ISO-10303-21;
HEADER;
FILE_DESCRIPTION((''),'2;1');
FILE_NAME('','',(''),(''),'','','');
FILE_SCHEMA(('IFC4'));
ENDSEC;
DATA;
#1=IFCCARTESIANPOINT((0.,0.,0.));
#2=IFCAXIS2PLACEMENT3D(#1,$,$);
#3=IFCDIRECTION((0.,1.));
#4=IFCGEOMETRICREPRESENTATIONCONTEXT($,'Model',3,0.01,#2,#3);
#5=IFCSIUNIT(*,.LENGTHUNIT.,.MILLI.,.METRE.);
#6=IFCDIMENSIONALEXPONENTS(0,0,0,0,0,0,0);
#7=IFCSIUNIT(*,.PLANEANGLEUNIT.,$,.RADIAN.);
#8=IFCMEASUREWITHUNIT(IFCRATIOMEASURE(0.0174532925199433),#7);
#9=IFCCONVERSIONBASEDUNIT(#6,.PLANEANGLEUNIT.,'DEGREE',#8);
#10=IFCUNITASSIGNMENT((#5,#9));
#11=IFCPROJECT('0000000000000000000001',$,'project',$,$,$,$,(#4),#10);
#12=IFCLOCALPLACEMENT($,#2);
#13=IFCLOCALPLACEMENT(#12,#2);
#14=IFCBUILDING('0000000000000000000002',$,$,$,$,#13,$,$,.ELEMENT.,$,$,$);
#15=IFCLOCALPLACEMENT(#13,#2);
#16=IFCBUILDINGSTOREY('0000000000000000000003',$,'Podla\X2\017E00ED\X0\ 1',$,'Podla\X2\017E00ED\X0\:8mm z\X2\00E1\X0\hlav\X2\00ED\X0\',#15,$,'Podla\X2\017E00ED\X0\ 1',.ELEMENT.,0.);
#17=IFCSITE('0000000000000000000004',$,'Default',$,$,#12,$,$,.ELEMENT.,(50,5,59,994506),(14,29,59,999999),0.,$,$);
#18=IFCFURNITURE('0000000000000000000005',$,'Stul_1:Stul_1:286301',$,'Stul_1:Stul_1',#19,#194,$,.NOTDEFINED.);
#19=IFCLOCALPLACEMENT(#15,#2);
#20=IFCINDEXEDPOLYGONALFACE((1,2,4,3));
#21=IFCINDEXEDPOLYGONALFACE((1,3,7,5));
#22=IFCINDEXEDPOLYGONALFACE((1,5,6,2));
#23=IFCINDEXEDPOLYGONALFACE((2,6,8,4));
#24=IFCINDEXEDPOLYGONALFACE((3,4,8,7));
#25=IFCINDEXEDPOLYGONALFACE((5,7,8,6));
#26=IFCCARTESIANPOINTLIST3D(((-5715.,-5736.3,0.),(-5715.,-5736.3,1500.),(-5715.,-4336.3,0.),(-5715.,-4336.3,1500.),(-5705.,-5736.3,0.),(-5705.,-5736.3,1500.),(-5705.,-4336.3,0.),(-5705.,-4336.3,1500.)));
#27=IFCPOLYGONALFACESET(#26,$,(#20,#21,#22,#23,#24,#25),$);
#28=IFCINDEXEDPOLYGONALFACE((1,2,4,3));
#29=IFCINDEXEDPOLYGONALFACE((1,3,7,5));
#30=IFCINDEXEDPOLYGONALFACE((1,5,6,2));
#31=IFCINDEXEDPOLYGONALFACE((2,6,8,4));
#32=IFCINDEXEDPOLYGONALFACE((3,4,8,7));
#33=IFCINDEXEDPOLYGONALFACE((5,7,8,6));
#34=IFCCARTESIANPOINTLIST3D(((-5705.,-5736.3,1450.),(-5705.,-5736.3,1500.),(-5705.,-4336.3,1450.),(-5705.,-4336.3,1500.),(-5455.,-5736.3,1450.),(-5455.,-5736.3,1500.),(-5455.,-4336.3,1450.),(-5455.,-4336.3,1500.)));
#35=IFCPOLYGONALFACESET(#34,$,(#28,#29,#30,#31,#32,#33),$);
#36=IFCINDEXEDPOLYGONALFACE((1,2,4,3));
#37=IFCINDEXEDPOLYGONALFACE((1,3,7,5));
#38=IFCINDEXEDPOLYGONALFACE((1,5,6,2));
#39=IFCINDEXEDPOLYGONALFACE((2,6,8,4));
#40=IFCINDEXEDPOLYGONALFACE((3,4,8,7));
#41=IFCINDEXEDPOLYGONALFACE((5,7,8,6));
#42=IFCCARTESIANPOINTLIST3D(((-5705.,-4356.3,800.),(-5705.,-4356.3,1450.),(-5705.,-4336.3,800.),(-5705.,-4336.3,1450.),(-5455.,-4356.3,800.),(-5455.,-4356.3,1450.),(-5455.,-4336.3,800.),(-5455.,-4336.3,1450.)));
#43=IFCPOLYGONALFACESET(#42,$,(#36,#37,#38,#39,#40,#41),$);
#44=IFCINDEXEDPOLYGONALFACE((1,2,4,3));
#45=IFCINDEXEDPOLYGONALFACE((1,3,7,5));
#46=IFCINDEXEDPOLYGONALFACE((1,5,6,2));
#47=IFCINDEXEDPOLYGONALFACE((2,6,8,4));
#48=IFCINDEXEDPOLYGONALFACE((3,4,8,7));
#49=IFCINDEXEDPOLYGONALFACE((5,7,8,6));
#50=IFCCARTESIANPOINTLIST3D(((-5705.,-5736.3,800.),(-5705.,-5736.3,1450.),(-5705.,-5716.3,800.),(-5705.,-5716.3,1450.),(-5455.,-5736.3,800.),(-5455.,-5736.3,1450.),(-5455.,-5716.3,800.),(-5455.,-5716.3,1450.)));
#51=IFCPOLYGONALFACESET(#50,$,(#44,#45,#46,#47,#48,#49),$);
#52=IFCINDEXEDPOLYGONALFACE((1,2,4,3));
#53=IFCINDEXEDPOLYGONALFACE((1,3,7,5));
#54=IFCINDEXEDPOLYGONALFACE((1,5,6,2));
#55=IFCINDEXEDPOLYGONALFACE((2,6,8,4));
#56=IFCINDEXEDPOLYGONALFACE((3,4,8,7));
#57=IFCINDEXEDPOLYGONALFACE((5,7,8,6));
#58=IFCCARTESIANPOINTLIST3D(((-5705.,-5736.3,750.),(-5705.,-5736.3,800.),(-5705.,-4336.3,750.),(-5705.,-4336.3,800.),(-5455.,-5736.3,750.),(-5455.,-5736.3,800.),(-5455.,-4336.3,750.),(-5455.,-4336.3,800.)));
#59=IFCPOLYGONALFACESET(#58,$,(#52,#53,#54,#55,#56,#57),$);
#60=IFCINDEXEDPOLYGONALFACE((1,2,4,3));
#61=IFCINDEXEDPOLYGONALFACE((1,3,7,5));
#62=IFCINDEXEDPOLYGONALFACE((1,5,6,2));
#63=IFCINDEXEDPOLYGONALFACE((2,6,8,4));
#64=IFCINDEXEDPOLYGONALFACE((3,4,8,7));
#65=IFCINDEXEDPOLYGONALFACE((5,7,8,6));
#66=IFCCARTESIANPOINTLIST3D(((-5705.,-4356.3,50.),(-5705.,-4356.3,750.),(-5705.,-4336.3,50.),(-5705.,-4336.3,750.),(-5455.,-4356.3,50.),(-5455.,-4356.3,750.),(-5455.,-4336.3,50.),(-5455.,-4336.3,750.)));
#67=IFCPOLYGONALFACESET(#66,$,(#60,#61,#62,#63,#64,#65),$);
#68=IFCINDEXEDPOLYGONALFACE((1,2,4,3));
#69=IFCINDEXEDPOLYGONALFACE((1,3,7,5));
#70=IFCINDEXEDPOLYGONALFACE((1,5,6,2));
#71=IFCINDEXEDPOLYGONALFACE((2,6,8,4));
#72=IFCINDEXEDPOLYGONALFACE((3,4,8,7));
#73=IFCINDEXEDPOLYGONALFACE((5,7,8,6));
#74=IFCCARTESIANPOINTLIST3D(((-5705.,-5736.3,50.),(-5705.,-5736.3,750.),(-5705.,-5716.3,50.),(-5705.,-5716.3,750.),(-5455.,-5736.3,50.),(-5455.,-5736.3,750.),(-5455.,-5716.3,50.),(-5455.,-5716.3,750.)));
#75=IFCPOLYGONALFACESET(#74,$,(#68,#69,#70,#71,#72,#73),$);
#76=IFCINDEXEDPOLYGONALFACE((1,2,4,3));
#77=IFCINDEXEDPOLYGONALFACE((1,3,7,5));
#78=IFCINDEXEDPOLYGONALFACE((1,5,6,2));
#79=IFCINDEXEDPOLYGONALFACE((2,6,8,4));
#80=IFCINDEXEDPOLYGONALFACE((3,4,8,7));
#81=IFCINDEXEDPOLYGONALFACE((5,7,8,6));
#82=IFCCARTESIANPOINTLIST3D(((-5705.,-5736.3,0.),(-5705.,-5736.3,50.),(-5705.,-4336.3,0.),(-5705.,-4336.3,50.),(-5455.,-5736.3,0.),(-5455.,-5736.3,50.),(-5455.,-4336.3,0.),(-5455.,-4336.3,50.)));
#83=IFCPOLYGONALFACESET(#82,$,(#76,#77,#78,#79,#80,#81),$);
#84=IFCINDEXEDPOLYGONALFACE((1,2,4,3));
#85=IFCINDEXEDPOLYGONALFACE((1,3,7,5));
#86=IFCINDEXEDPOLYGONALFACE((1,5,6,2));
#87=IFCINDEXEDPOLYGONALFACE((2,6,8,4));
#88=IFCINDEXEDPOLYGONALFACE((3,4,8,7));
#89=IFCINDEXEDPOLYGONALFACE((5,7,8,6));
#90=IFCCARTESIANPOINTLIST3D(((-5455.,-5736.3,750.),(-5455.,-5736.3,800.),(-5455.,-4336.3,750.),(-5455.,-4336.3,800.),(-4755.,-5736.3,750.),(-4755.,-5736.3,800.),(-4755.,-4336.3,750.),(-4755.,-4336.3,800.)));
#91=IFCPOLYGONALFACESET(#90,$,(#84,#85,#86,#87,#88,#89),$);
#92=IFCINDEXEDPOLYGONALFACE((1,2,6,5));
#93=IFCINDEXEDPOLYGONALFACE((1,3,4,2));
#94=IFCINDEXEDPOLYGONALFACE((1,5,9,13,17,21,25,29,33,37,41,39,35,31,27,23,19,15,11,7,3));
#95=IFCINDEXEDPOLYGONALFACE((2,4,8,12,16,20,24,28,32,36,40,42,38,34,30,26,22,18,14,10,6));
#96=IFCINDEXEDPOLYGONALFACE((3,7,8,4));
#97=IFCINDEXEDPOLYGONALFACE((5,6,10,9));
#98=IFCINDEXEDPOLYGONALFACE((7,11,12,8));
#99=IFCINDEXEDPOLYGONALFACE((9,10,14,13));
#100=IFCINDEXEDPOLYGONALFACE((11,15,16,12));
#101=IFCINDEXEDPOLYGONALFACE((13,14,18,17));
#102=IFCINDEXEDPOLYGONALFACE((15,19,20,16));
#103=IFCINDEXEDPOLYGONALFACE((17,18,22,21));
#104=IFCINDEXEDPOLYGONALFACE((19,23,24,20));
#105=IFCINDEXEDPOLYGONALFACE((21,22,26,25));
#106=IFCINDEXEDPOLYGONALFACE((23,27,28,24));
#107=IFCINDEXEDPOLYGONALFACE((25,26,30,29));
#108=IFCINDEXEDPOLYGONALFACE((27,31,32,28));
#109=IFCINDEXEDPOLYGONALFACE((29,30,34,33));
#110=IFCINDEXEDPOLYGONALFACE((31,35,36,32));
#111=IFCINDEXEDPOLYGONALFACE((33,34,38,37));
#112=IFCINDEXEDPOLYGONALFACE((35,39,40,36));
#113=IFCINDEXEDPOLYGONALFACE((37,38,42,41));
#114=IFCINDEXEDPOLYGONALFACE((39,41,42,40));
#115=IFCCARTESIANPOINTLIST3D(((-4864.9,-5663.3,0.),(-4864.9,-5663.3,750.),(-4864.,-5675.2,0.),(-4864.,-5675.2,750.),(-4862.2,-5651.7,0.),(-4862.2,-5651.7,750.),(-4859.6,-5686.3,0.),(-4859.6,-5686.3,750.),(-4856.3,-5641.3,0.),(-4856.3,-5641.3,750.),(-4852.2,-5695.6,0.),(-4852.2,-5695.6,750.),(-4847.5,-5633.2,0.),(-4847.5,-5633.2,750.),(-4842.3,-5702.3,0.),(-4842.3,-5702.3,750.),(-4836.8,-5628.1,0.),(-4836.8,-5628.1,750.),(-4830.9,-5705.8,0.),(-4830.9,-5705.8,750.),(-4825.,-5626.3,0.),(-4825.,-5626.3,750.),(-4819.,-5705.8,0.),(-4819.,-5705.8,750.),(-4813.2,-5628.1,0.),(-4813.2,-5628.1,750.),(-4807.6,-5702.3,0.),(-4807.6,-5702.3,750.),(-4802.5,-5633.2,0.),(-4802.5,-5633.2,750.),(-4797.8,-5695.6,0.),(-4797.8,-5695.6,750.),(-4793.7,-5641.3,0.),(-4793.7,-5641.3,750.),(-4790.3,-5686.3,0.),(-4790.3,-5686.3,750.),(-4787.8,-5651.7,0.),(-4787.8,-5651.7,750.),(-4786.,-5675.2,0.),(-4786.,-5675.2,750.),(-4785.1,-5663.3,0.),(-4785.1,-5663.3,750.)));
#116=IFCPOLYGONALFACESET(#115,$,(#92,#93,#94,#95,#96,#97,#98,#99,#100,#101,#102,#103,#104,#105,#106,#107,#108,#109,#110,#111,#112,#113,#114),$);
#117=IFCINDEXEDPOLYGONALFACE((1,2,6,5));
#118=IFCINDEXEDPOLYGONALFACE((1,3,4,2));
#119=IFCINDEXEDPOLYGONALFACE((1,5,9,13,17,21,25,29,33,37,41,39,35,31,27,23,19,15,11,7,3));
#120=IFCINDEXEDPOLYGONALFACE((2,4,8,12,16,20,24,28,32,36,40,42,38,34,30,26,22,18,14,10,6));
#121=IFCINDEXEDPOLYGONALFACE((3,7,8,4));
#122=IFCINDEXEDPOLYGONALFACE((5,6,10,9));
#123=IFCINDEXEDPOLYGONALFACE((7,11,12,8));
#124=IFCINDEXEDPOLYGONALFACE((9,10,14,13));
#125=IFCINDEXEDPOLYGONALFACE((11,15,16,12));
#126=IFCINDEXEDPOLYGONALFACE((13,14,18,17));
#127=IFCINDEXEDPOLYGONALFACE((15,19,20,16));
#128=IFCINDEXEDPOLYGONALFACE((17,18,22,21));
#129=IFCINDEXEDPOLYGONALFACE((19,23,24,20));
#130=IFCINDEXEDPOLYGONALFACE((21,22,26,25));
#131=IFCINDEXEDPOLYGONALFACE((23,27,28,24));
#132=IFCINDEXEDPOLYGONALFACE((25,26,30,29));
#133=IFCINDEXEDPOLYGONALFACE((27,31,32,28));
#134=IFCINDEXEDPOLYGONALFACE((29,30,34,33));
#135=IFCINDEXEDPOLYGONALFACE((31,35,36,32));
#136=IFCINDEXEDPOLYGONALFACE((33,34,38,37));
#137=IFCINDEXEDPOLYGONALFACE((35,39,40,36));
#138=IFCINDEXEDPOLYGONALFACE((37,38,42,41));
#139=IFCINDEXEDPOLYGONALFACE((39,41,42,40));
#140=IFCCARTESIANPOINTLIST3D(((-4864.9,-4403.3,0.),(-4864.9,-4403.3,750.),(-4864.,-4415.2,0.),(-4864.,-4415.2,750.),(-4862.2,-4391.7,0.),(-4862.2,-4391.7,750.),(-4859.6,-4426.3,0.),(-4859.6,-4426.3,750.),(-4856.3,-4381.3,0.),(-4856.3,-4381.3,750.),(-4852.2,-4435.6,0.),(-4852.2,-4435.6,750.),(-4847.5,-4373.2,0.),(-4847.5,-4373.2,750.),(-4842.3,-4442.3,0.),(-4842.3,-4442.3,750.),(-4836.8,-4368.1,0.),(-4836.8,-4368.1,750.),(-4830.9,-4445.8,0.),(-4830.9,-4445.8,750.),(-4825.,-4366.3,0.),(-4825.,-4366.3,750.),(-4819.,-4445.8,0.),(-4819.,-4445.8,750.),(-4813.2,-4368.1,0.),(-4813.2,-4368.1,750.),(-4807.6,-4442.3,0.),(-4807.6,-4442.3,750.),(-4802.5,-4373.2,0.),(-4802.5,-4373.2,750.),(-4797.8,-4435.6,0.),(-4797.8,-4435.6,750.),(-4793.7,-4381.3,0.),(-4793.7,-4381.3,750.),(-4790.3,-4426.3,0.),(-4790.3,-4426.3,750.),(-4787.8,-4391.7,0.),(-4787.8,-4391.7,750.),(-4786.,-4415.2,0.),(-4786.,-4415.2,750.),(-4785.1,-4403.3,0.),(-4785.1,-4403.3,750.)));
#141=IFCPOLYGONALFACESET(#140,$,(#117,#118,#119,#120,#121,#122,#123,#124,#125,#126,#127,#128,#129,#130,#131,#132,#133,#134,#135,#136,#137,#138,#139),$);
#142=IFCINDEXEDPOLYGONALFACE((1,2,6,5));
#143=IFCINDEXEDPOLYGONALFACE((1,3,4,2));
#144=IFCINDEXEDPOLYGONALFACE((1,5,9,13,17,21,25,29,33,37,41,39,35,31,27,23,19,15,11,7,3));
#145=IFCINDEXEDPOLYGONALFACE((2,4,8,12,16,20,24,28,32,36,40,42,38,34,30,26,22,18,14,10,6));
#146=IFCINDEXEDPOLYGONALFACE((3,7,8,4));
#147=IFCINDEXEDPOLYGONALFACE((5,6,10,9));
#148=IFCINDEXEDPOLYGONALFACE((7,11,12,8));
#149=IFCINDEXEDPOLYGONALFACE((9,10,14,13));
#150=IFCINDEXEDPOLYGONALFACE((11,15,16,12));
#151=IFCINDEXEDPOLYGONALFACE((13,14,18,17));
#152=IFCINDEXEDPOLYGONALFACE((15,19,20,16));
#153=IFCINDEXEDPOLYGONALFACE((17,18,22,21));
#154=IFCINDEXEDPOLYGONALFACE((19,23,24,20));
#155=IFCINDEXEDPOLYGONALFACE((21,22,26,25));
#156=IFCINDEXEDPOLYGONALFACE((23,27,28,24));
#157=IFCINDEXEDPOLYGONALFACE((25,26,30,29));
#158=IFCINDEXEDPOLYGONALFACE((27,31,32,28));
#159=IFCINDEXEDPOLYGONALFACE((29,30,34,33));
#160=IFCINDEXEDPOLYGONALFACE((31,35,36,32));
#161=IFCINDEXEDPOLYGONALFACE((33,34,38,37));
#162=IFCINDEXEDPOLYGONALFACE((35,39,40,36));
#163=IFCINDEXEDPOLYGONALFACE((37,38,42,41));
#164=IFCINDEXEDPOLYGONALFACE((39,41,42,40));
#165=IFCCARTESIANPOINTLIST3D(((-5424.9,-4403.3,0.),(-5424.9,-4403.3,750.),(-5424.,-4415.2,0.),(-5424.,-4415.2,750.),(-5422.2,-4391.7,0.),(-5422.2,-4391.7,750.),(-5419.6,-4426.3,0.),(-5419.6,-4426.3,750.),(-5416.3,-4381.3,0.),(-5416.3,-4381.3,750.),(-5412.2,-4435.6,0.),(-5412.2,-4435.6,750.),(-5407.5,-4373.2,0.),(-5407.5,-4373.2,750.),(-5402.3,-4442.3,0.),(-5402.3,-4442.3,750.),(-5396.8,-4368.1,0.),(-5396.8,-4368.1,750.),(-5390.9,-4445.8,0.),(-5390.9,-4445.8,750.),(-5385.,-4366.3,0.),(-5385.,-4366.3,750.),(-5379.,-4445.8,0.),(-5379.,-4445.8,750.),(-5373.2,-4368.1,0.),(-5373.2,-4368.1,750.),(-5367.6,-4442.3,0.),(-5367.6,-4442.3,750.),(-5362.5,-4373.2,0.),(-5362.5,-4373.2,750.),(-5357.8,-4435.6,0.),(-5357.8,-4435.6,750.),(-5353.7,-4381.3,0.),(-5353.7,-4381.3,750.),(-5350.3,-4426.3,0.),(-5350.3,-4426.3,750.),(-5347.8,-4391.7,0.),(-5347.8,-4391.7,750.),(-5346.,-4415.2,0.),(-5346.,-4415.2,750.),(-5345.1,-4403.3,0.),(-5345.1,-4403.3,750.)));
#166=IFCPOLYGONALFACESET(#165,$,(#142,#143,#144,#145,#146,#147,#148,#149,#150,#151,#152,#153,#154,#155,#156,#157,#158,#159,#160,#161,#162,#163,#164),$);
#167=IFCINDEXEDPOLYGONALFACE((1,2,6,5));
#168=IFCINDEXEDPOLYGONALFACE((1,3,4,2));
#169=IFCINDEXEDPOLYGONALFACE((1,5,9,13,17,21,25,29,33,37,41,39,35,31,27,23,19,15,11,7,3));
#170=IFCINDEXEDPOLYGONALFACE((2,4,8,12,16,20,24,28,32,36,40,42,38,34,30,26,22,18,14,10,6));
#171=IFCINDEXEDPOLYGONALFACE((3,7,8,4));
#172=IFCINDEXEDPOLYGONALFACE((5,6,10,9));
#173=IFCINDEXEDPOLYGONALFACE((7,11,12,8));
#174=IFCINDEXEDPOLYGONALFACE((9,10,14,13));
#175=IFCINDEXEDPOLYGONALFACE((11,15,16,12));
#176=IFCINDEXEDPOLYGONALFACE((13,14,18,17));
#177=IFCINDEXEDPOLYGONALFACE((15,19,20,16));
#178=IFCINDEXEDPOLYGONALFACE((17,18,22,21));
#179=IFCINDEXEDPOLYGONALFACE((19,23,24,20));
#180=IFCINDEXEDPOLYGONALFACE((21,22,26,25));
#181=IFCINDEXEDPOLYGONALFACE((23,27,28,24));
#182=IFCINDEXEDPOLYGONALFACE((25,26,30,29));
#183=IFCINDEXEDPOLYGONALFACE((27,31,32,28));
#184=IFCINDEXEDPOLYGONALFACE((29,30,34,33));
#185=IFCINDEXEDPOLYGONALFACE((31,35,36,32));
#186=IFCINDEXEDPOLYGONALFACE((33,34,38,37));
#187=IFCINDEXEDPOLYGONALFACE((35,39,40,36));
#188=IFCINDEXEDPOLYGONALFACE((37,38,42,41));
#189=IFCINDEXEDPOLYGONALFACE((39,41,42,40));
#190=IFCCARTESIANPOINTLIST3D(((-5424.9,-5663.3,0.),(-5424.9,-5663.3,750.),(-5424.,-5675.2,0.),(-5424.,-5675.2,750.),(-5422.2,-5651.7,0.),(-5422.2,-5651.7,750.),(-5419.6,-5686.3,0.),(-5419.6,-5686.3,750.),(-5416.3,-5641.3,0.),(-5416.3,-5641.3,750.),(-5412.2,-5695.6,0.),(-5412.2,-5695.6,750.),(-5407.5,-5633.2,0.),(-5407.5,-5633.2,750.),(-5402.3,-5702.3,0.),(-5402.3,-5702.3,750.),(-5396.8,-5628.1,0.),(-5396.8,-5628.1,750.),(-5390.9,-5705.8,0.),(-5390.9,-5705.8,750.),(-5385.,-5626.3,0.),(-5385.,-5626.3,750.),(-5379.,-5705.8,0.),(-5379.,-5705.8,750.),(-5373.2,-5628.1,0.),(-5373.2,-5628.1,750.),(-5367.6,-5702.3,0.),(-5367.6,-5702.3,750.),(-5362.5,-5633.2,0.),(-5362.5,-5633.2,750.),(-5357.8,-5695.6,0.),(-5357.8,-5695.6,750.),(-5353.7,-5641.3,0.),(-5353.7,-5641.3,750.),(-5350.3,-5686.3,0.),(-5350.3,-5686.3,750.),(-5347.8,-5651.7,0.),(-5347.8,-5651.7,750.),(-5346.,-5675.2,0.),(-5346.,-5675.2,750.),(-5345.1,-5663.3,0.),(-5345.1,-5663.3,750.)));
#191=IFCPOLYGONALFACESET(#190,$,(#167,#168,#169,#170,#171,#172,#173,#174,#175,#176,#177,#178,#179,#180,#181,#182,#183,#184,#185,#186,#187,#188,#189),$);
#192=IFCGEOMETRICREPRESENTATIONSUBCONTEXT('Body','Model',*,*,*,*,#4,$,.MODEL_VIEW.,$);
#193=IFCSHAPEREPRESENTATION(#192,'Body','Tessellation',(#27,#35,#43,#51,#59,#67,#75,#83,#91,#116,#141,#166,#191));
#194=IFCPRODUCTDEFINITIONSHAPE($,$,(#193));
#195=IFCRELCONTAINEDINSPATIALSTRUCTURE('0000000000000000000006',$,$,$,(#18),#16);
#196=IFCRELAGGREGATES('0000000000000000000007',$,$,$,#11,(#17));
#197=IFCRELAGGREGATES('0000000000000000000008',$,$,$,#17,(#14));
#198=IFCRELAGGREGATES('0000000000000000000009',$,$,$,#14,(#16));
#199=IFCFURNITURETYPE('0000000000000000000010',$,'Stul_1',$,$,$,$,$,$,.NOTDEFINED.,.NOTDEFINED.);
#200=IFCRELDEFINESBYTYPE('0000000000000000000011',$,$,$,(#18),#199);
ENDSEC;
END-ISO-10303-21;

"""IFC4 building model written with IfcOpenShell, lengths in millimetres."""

from ifc_helpers import new_model, entity, si_unit, converted_unit, direction, frame, frame_2d, origin, origin_2d_with_axis, place, context, subcontext, project, spatial, rectangle, circle, extrude, source, transform, mapped, type_object, type_shapes, element, save


model = new_model("IFC4")

# Units and contexts
model_context = context("Model", 3, precision=0.01, world=origin(), true_north=direction((0.0, 1.0)))
body_context = subcontext(model_context, "Body", "Model", "MODEL_VIEW")
ifc_project = project(units=[si_unit("LENGTHUNIT", "METRE", prefix="MILLI"), converted_unit("PLANEANGLEUNIT", "DEGREE", entity("IfcRatioMeasure", 0.0174532925199433), si_unit("PLANEANGLEUNIT", "RADIAN"), dimensions=[0, 0, 0, 0, 0, 0, 0])], contexts=[model_context])

# Site, building, storey
site_placement = place(None, origin())
site = spatial("IfcSite", under=ifc_project, at=site_placement, Name="Default", CompositionType="ELEMENT", RefLatitude=(50, 5, 59, 994506), RefLongitude=(14, 29, 59, 999999), RefElevation=0.0)
building_placement = place(site_placement, origin())
building = spatial("IfcBuilding", under=site, at=building_placement, CompositionType="ELEMENT")
storey_placement = place(building_placement, origin())
storey = spatial("IfcBuildingStorey", under=building, at=storey_placement, Name="Podlaží 1", ObjectType="Podlaží:8mm záhlaví", LongName="Podlaží 1", CompositionType="ELEMENT", Elevation=0.0)

# Furniture
furniture_type = type_object("IfcFurnitureType", Name="Stul_1", AssemblyPlace="NOTDEFINED", PredefinedType="NOTDEFINED")
shared_shape_1 = source(origin(), body_context, "Body", "SweptSolid", [
    extrude(rectangle(XDim=1400.0, YDim=10.0, at=origin_2d_with_axis()), frame((0.0, 605.0, 0.0), z_axis=(0.0, 0.0, 1.0), x_axis=(-1.0, 0.0, 0.0)), (0.0, 0.0, 1.0), 1500.0),
    extrude(rectangle(XDim=1400.0, YDim=250.0, at=frame_2d((0.0, 0.0), x_axis=(1.0, 0.0))), frame((0.0, 475.0, 1450.0), z_axis=(0.0, 0.0, 1.0), x_axis=(-1.0, 0.0, 0.0)), (0.0, 0.0, 1.0), 50.0),
    extrude(rectangle(XDim=20.0, YDim=250.0, at=origin_2d_with_axis()), frame((690.0, 475.0, 800.0), z_axis=(0.0, 0.0, 1.0), x_axis=(-1.0, 0.0, 0.0)), (0.0, 0.0, 1.0), 650.0),
    extrude(rectangle(XDim=20.0, YDim=250.0, at=frame_2d((0.0, 0.0), x_axis=(1.0, 0.0))), frame((-690.0, 475.0, 800.0), z_axis=(0.0, 0.0, 1.0), x_axis=(-1.0, 0.0, 0.0)), (0.0, 0.0, 1.0), 650.0),
    extrude(rectangle(XDim=1400.0, YDim=250.0, at=origin_2d_with_axis()), frame((0.0, 475.0, 750.0), z_axis=(0.0, 0.0, 1.0), x_axis=(-1.0, 0.0, 0.0)), (0.0, 0.0, 1.0), 50.0),
    extrude(rectangle(XDim=20.0, YDim=250.0, at=origin_2d_with_axis()), frame((690.0, 475.0, 50.0), z_axis=(0.0, 0.0, 1.0), x_axis=(-1.0, 0.0, 0.0)), (0.0, 0.0, 1.0), 700.0),
    extrude(rectangle(XDim=20.0, YDim=250.0, at=frame_2d((0.0, 0.0), x_axis=(1.0, 0.0))), frame((-690.0, 475.0, 50.0), z_axis=(0.0, 0.0, 1.0), x_axis=(-1.0, 0.0, 0.0)), (0.0, 0.0, 1.0), 700.0),
    extrude(rectangle(XDim=1400.0, YDim=250.0, at=origin_2d_with_axis()), frame((0.0, 475.0, 0.0), z_axis=(0.0, 0.0, 1.0), x_axis=(-1.0, 0.0, 0.0)), (0.0, 0.0, 1.0), 50.0),
    extrude(rectangle(XDim=1400.0, YDim=700.0, at=origin_2d_with_axis()), frame((0.0, 0.0, 750.0), z_axis=(0.0, 0.0, 1.0), x_axis=(-1.0, 0.0, 0.0)), (0.0, 0.0, 1.0), 50.0),
    extrude(circle(Radius=40.0, at=frame_2d((0.0, 0.0), x_axis=(1.0, 0.0))), frame((-630.0, -280.0, 0.0)), (0.0, 0.0, 1.0), 750.0),
    extrude(circle(Radius=40.0, at=frame_2d((0.0, 0.0), x_axis=(1.0, 0.0))), frame((630.0, -280.0, 0.0)), (0.0, 0.0, 1.0), 750.0),
    extrude(circle(Radius=40.0, at=frame_2d((0.0, 0.0), x_axis=(1.0, 0.0))), frame((630.0, 280.0, 0.0)), (0.0, 0.0, 1.0), 750.0),
    extrude(circle(Radius=40.0, at=frame_2d((0.0, 0.0), x_axis=(1.0, 0.0))), frame((-630.0, 280.0, 0.0)), (0.0, 0.0, 1.0), 750.0),
])
type_shapes(furniture_type, [shared_shape_1])
for number, where, z_axis, x_axis, name in (
    (1, (-5105.0, -5036.3, 0.0), (0.0, 0.0, 1.0), (0.0, 1.0, 0.0), "Stul_1:Stul_1:286301"),
):
    element("IfcFurniture", number, at=place(storey_placement, frame(where, z_axis=z_axis, x_axis=x_axis)), inside=storey, type_object=furniture_type, Name=name, ObjectType="Stul_1:Stul_1", PredefinedType="NOTDEFINED", context=body_context, shape_type="MappedRepresentation", body=[
        mapped(shared_shape_1, transform((0.0, 0.0, 0.0), scale=1.0)),
    ])

save(model, "model.ifc")
